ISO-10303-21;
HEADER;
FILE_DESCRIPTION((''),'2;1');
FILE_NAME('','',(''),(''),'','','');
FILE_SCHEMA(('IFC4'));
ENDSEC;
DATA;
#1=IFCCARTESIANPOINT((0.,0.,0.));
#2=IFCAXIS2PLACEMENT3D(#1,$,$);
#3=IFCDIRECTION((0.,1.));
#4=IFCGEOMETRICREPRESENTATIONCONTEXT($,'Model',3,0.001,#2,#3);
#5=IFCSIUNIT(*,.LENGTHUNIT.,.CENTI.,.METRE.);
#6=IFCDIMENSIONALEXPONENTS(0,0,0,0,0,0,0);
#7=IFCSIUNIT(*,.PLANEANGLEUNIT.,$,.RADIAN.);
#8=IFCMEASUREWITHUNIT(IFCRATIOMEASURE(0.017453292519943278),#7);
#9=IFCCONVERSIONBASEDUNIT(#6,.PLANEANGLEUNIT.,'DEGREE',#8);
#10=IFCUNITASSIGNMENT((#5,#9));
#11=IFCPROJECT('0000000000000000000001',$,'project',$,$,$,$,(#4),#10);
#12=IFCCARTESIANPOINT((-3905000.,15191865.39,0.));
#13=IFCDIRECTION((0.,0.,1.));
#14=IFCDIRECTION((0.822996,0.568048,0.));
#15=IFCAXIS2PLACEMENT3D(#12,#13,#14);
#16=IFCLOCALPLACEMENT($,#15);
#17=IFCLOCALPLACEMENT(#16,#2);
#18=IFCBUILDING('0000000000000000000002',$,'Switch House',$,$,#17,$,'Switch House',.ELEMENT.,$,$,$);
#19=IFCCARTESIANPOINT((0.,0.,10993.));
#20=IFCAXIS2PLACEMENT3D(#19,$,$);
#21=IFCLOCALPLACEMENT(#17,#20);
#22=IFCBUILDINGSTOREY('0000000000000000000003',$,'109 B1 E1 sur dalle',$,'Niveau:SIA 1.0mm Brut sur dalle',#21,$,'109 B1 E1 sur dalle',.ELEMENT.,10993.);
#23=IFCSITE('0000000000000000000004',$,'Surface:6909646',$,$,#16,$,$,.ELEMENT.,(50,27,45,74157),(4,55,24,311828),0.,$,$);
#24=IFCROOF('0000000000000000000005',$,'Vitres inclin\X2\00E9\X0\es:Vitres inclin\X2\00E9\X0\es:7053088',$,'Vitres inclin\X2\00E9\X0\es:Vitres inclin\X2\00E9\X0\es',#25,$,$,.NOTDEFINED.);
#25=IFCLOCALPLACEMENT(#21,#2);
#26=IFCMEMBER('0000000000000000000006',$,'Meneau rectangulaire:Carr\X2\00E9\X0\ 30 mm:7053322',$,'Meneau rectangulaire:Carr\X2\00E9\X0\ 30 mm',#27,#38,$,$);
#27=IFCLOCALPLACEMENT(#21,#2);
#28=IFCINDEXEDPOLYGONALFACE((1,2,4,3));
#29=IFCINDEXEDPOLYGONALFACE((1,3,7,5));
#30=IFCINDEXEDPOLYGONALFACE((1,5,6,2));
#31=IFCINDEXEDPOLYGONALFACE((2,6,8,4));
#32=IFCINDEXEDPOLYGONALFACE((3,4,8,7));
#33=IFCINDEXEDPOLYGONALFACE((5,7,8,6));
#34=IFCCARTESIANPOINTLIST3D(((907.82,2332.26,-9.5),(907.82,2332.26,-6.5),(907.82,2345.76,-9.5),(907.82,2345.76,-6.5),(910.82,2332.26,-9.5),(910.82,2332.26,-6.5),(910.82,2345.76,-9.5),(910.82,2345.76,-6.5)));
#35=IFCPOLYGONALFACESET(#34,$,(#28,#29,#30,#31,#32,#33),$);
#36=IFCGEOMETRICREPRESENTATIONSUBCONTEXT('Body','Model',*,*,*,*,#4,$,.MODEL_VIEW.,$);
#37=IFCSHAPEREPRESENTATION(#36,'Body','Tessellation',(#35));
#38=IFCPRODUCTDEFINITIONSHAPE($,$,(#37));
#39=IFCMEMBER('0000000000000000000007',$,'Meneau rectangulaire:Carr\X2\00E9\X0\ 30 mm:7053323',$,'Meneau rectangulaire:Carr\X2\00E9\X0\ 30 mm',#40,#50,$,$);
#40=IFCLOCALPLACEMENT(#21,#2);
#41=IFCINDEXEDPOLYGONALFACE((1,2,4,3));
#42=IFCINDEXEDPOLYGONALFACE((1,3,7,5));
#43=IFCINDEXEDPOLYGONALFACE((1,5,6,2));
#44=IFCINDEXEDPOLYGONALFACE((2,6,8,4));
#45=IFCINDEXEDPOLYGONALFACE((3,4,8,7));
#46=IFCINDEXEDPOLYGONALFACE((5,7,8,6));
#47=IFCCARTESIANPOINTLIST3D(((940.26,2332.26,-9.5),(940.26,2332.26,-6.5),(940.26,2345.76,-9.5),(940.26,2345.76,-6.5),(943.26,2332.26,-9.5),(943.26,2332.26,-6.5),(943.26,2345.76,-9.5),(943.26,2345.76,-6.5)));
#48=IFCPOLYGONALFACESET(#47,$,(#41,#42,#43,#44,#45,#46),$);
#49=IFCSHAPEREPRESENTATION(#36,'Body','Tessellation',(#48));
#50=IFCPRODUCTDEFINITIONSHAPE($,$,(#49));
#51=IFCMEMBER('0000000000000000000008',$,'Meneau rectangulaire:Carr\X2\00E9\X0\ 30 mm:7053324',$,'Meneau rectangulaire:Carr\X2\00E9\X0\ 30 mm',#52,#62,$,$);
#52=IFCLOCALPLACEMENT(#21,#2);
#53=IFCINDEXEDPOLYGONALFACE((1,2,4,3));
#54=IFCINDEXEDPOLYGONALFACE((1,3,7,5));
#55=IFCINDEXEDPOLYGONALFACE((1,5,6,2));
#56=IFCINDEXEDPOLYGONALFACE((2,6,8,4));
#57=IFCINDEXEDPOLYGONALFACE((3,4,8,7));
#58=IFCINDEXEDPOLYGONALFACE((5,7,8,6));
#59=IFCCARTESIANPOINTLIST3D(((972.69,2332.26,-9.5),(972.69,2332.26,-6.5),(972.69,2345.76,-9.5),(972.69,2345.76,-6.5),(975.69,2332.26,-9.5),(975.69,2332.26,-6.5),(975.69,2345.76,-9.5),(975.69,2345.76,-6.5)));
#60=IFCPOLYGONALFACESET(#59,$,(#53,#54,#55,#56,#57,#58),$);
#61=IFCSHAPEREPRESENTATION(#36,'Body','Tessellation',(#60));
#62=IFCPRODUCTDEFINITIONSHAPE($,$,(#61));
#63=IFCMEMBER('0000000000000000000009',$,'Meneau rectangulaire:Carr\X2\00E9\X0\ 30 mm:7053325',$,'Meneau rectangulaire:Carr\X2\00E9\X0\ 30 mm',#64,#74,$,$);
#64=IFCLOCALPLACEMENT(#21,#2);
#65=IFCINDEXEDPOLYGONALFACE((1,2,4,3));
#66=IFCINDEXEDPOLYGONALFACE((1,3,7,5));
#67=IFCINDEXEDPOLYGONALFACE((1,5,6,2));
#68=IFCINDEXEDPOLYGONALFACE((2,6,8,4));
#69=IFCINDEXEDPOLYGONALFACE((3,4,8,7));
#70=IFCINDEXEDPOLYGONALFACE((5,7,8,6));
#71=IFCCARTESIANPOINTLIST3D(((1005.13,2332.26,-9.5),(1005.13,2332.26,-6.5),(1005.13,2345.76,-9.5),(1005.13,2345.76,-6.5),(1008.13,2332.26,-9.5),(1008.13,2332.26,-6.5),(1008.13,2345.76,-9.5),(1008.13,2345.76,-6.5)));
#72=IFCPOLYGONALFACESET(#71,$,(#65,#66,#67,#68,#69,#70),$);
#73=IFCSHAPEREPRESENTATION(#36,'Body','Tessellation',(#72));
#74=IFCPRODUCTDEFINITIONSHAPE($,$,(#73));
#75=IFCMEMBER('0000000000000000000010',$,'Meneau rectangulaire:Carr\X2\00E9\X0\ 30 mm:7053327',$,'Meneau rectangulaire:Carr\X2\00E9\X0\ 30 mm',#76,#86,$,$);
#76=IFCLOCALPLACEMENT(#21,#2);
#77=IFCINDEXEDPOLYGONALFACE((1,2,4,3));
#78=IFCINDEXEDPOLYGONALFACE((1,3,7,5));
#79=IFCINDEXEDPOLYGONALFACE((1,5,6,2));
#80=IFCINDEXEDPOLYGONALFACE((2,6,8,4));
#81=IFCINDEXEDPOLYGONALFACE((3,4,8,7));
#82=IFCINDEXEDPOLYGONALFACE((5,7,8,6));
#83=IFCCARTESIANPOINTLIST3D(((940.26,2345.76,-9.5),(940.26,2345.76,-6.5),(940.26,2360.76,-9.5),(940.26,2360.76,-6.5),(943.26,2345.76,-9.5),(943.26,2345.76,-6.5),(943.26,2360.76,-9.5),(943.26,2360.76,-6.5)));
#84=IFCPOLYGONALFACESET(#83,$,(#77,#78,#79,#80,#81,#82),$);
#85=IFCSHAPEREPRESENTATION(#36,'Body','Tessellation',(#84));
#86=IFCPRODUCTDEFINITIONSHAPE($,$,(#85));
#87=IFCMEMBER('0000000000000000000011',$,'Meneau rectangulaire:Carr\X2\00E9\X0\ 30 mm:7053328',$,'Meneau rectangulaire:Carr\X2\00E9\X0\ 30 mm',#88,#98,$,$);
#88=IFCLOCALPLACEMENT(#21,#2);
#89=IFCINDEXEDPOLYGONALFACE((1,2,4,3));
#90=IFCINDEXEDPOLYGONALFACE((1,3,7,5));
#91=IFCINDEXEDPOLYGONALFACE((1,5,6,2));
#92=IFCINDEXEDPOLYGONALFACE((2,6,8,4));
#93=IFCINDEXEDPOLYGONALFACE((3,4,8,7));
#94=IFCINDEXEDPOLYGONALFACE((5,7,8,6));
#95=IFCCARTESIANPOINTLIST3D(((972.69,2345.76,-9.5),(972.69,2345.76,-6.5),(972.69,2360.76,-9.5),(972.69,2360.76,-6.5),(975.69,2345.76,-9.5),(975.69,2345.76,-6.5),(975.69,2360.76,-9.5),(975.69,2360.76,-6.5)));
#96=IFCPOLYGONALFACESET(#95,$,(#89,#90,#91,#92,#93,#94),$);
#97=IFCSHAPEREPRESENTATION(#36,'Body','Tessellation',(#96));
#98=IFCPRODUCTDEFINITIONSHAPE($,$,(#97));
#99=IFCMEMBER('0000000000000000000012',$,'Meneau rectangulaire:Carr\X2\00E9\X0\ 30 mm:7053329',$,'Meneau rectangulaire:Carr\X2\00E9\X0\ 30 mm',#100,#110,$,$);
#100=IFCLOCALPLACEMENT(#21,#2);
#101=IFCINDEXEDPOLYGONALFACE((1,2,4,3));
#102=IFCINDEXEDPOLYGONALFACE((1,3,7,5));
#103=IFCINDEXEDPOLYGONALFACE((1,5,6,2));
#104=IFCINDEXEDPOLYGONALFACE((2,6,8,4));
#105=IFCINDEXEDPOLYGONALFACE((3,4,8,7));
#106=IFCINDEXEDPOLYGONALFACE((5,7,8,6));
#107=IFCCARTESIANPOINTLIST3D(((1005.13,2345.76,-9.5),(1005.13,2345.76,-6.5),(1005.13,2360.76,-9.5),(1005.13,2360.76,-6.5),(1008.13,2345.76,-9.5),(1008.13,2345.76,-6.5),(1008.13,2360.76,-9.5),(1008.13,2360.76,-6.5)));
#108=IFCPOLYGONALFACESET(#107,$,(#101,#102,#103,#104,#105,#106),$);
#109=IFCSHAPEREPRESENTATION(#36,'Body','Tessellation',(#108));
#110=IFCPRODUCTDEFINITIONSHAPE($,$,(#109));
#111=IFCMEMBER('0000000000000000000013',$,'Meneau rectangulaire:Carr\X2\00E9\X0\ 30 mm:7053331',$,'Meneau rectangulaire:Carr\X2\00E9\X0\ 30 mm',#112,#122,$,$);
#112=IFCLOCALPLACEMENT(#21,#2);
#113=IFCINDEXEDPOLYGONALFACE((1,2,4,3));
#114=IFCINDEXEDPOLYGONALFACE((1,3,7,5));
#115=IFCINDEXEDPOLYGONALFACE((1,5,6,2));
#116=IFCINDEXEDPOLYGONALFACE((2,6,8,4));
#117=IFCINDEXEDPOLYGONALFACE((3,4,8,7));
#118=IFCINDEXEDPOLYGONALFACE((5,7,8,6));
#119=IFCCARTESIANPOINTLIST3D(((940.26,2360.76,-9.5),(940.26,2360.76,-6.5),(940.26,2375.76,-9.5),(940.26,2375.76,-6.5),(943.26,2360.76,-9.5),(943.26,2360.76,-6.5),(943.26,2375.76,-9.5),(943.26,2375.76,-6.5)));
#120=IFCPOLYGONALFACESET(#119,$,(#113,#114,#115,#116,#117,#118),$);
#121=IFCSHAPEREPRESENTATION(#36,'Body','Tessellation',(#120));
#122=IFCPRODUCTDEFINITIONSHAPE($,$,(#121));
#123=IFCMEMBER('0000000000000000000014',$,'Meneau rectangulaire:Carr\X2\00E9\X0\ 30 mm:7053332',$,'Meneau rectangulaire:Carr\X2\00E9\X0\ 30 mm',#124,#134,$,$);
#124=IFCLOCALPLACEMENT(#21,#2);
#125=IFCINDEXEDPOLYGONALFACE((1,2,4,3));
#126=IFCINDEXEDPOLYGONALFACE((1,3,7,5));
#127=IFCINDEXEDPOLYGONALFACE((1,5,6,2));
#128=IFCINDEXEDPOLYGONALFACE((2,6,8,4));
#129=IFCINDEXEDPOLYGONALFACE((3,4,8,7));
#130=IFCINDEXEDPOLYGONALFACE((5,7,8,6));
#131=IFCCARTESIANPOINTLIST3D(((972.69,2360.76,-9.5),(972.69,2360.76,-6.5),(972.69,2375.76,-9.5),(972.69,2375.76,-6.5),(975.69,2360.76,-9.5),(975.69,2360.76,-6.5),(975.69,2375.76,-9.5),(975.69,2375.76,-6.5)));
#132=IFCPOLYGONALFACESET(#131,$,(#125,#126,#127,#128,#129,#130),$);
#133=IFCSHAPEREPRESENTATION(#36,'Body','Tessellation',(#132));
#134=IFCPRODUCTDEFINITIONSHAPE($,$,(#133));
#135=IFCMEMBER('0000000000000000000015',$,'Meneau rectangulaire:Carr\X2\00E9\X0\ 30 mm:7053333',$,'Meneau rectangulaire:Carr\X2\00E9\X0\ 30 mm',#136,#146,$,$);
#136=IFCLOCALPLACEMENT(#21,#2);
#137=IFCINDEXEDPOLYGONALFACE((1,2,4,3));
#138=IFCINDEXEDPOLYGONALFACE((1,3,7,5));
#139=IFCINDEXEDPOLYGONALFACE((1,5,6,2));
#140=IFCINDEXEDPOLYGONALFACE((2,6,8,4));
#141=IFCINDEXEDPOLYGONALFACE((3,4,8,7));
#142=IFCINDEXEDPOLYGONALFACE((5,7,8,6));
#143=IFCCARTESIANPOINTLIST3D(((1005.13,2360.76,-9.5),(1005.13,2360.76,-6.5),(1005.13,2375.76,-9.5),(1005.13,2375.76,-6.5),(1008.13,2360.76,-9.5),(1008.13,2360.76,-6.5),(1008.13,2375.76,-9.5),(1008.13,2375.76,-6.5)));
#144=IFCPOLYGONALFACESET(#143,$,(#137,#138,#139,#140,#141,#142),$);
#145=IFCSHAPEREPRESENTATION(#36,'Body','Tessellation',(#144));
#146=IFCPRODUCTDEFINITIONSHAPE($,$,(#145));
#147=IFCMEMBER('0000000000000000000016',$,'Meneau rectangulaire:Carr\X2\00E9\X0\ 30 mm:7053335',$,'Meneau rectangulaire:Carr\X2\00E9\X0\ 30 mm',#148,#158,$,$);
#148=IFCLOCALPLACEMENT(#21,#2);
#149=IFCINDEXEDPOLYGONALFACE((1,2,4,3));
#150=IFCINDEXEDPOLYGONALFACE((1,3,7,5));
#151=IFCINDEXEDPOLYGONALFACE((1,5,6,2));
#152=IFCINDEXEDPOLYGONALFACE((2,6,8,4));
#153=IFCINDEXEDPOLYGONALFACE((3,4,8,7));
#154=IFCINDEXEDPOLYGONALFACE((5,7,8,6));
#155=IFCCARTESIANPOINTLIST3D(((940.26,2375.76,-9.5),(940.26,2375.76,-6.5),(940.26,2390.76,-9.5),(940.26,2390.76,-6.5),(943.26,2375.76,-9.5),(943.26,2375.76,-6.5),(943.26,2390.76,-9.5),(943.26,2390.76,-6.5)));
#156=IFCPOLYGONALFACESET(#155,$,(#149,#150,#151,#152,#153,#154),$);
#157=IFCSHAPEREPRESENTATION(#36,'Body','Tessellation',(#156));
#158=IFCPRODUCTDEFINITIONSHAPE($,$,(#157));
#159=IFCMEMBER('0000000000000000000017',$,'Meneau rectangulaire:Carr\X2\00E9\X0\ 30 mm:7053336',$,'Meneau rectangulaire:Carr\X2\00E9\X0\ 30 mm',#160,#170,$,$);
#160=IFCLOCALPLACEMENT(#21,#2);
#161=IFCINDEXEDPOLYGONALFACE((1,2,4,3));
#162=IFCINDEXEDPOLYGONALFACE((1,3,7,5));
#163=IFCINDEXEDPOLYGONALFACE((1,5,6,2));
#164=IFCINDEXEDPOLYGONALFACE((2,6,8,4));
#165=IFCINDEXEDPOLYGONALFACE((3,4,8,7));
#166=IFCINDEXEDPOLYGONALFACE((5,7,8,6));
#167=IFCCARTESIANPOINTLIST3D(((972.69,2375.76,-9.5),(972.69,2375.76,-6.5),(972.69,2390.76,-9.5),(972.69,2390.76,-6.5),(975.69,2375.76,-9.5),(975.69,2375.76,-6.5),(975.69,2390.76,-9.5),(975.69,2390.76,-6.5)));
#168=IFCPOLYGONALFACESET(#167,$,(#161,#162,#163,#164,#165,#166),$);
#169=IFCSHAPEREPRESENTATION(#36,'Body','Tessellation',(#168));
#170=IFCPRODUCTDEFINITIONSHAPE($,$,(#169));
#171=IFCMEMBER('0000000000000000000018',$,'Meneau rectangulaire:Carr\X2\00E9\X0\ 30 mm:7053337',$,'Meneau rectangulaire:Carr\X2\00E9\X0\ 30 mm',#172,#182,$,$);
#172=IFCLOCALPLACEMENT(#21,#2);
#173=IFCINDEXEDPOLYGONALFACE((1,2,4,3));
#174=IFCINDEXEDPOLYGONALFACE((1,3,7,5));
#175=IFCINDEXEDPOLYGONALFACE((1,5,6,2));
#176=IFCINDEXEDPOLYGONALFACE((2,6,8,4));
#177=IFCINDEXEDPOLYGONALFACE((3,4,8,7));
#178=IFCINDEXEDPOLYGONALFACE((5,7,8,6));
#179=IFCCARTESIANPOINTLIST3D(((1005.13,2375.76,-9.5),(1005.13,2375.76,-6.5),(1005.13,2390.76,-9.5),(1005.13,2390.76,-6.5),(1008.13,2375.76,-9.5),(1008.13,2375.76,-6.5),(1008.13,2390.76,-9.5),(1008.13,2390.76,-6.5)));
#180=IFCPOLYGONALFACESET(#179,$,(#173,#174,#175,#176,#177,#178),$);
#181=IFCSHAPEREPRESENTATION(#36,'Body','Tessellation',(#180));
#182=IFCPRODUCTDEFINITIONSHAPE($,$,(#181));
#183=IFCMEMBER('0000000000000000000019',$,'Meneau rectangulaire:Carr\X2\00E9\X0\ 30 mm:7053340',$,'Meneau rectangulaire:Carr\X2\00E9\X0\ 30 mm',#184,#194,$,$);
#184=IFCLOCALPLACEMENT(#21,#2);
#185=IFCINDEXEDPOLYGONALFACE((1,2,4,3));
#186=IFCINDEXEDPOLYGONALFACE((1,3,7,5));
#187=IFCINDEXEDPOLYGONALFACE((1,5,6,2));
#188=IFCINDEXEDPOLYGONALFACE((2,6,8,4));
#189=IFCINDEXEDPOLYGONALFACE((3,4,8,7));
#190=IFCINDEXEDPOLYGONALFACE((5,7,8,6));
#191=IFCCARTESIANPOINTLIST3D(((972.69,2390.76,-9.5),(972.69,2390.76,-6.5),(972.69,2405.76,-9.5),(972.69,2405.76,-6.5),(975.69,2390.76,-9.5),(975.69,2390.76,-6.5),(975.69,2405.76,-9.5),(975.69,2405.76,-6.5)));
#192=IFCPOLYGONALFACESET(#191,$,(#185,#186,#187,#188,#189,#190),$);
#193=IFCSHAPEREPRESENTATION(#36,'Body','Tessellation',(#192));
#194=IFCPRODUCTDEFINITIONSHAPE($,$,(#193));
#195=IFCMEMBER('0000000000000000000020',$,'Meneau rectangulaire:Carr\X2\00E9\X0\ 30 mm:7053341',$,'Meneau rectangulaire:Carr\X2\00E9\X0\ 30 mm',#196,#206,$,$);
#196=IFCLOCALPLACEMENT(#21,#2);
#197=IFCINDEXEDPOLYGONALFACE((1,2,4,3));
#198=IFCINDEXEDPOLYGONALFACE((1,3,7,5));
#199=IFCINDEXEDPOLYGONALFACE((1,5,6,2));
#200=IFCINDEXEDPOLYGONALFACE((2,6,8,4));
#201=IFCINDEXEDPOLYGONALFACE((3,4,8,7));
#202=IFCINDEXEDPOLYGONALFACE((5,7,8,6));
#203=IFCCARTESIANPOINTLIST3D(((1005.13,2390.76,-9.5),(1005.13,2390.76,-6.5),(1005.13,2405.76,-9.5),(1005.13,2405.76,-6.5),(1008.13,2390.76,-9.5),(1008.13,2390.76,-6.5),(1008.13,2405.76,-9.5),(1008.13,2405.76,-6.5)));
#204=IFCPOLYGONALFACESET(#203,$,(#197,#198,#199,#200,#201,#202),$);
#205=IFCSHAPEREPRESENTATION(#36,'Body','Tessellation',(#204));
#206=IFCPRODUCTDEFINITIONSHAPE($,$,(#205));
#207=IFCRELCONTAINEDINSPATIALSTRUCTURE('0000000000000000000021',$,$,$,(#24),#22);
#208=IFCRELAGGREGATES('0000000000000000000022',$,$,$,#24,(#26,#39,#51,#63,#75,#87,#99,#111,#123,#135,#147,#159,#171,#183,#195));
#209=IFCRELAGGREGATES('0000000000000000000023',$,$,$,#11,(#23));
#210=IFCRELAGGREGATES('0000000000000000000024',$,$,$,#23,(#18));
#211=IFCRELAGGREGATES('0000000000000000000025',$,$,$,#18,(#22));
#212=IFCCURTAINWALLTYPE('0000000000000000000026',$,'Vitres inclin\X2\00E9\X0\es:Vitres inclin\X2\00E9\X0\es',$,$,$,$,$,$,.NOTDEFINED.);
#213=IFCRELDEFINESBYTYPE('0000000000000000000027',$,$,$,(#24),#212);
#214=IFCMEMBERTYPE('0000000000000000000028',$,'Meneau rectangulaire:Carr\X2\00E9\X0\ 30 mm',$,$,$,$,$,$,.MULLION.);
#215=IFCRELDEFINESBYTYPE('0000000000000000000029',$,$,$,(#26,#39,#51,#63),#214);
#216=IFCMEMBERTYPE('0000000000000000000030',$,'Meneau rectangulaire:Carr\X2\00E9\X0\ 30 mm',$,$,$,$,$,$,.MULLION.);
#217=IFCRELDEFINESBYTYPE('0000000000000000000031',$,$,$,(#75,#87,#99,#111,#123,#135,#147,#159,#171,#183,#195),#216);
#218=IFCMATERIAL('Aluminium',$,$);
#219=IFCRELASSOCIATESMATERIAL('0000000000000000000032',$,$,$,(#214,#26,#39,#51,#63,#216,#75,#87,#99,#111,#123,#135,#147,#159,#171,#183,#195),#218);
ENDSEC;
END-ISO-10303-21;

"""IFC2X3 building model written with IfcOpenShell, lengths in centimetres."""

from ifc_helpers import new_model, entity, si_unit, converted_unit, direction, frame, origin, origin_2d_with_axis, place, context, subcontext, project, spatial, rectangle, extrude, source, transform, mapped, material, type_object, type_shapes, element, aggregate, save


model = new_model("IFC2X3")

# Units and contexts
model_context = context("Model", 3, precision=0.001, world=origin(), true_north=direction((0.0, 1.0)))
body_context = subcontext(model_context, "Body", "Model", "MODEL_VIEW")
ifc_project = project(units=[si_unit("LENGTHUNIT", "METRE", prefix="CENTI"), converted_unit("PLANEANGLEUNIT", "DEGREE", entity("IfcRatioMeasure", 0.017453292519943278), si_unit("PLANEANGLEUNIT", "RADIAN"), dimensions=[0, 0, 0, 0, 0, 0, 0])], contexts=[model_context])

# Site, building, storey
site_placement = place(None, frame((-3905000.0, 15191865.39, 0.0), z_axis=(0.0, 0.0, 1.0), x_axis=(0.822996, 0.568048, 0.0)))
site = spatial("IfcSite", under=ifc_project, at=site_placement, Name="Surface:6909646", CompositionType="ELEMENT", RefLatitude=(50, 27, 45, 74157), RefLongitude=(4, 55, 24, 311828), RefElevation=0.0)
building_placement = place(site_placement, origin())
building = spatial("IfcBuilding", under=site, at=building_placement, Name="Switch House", LongName="Switch House", CompositionType="ELEMENT")
storey_placement = place(building_placement, frame((0.0, 0.0, 10993.0)))
storey = spatial("IfcBuildingStorey", under=building, at=storey_placement, Name="109 B1 E1 sur dalle", ObjectType="Niveau:SIA 1.0mm Brut sur dalle", LongName="109 B1 E1 sur dalle", CompositionType="ELEMENT", Elevation=10993.0)

# Roof, members
curtain_wall_type = type_object("IfcCurtainWallType", Name="Vitres inclinées:Vitres inclinées", PredefinedType="NOTDEFINED")
roof_placement = place(storey_placement, frame((0.0, 0.0, -10993.0)))
roof = element("IfcRoof", 1, at=roof_placement, inside=storey, type_object=curtain_wall_type, Name="Vitres inclinées:Vitres inclinées:7053088", ObjectType="Vitres inclinées:Vitres inclinées", ShapeType="NOTDEFINED")
ifc_material = material(Name="Aluminium")
member_type_1 = type_object("IfcMemberType", Name="Meneau rectangulaire:Carré 30 mm", PredefinedType="MULLION", material=ifc_material)
shared_shape_1 = source(origin(), body_context, "Body", "SweptSolid", [
    extrude(rectangle(XDim=3.0, YDim=3.0, at=origin_2d_with_axis()), frame((0.0, 0.0, -13.5), z_axis=(0.0, 0.0, 1.0), x_axis=(0.0, -1.0, 0.0)), (0.0, 0.0, 1.0), 13.5),
])
type_shapes(member_type_1, [shared_shape_1])
member_1_placement = place(roof_placement, frame((909.32, 2345.76, 10985.0), z_axis=(0.0, 1.0, 0.0), x_axis=(1.0, 0.0, 0.0)))
member_1 = element("IfcMember", 2, at=member_1_placement, type_object=member_type_1, material=ifc_material, Name="Meneau rectangulaire:Carré 30 mm:7053322", ObjectType="Meneau rectangulaire:Carré 30 mm", context=body_context, shape_type="MappedRepresentation", body=[
    mapped(shared_shape_1, transform((0.0, 0.0, 0.0), scale=1.0)),
])
member_2_placement = place(roof_placement, frame((941.76, 2345.76, 10985.0), z_axis=(0.0, 1.0, 0.0), x_axis=(1.0, 0.0, 0.0)))
member_2 = element("IfcMember", 3, at=member_2_placement, type_object=member_type_1, material=ifc_material, Name="Meneau rectangulaire:Carré 30 mm:7053323", ObjectType="Meneau rectangulaire:Carré 30 mm", context=body_context, shape_type="MappedRepresentation", body=[
    mapped(shared_shape_1, transform((0.0, 0.0, 0.0), scale=1.0)),
])
member_3_placement = place(roof_placement, frame((974.19, 2345.76, 10985.0), z_axis=(0.0, 1.0, 0.0), x_axis=(1.0, 0.0, 0.0)))
member_3 = element("IfcMember", 4, at=member_3_placement, type_object=member_type_1, material=ifc_material, Name="Meneau rectangulaire:Carré 30 mm:7053324", ObjectType="Meneau rectangulaire:Carré 30 mm", context=body_context, shape_type="MappedRepresentation", body=[
    mapped(shared_shape_1, transform((0.0, 0.0, 0.0), scale=1.0)),
])
member_4_placement = place(roof_placement, frame((1006.63, 2345.76, 10985.0), z_axis=(0.0, 1.0, 0.0), x_axis=(1.0, 0.0, 0.0)))
member_4 = element("IfcMember", 5, at=member_4_placement, type_object=member_type_1, material=ifc_material, Name="Meneau rectangulaire:Carré 30 mm:7053325", ObjectType="Meneau rectangulaire:Carré 30 mm", context=body_context, shape_type="MappedRepresentation", body=[
    mapped(shared_shape_1, transform((0.0, 0.0, 0.0), scale=1.0)),
])
member_type_2 = type_object("IfcMemberType", Name="Meneau rectangulaire:Carré 30 mm", PredefinedType="MULLION", material=ifc_material)
shared_shape_2 = source(origin(), body_context, "Body", "SweptSolid", [
    extrude(rectangle(XDim=3.0, YDim=3.0, at=origin_2d_with_axis()), frame((0.0, 0.0, -15.0), z_axis=(0.0, 0.0, 1.0), x_axis=(0.0, -1.0, 0.0)), (0.0, 0.0, 1.0), 15.0),
])
type_shapes(member_type_2, [shared_shape_2])
member_5_placement = place(roof_placement, frame((941.76, 2360.76, 10985.0), z_axis=(0.0, 1.0, 0.0), x_axis=(1.0, 0.0, 0.0)))
member_5 = element("IfcMember", 6, at=member_5_placement, type_object=member_type_2, material=ifc_material, Name="Meneau rectangulaire:Carré 30 mm:7053327", ObjectType="Meneau rectangulaire:Carré 30 mm", context=body_context, shape_type="MappedRepresentation", body=[
    mapped(shared_shape_2, transform((0.0, 0.0, 0.0), scale=1.0)),
])
member_6_placement = place(roof_placement, frame((974.19, 2360.76, 10985.0), z_axis=(0.0, 1.0, 0.0), x_axis=(1.0, 0.0, 0.0)))
member_6 = element("IfcMember", 7, at=member_6_placement, type_object=member_type_2, material=ifc_material, Name="Meneau rectangulaire:Carré 30 mm:7053328", ObjectType="Meneau rectangulaire:Carré 30 mm", context=body_context, shape_type="MappedRepresentation", body=[
    mapped(shared_shape_2, transform((0.0, 0.0, 0.0), scale=1.0)),
])
member_7_placement = place(roof_placement, frame((1006.63, 2360.76, 10985.0), z_axis=(0.0, 1.0, 0.0), x_axis=(1.0, 0.0, 0.0)))
member_7 = element("IfcMember", 8, at=member_7_placement, type_object=member_type_2, material=ifc_material, Name="Meneau rectangulaire:Carré 30 mm:7053329", ObjectType="Meneau rectangulaire:Carré 30 mm", context=body_context, shape_type="MappedRepresentation", body=[
    mapped(shared_shape_2, transform((0.0, 0.0, 0.0), scale=1.0)),
])
member_8_placement = place(roof_placement, frame((941.76, 2375.76, 10985.0), z_axis=(0.0, 1.0, 0.0), x_axis=(1.0, 0.0, 0.0)))
member_8 = element("IfcMember", 9, at=member_8_placement, type_object=member_type_2, material=ifc_material, Name="Meneau rectangulaire:Carré 30 mm:7053331", ObjectType="Meneau rectangulaire:Carré 30 mm", context=body_context, shape_type="MappedRepresentation", body=[
    mapped(shared_shape_2, transform((0.0, 0.0, 0.0), scale=1.0)),
])
member_9_placement = place(roof_placement, frame((974.19, 2375.76, 10985.0), z_axis=(0.0, 1.0, 0.0), x_axis=(1.0, 0.0, 0.0)))
member_9 = element("IfcMember", 10, at=member_9_placement, type_object=member_type_2, material=ifc_material, Name="Meneau rectangulaire:Carré 30 mm:7053332", ObjectType="Meneau rectangulaire:Carré 30 mm", context=body_context, shape_type="MappedRepresentation", body=[
    mapped(shared_shape_2, transform((0.0, 0.0, 0.0), scale=1.0)),
])
member_10_placement = place(roof_placement, frame((1006.63, 2375.76, 10985.0), z_axis=(0.0, 1.0, 0.0), x_axis=(1.0, 0.0, 0.0)))
member_10 = element("IfcMember", 11, at=member_10_placement, type_object=member_type_2, material=ifc_material, Name="Meneau rectangulaire:Carré 30 mm:7053333", ObjectType="Meneau rectangulaire:Carré 30 mm", context=body_context, shape_type="MappedRepresentation", body=[
    mapped(shared_shape_2, transform((0.0, 0.0, 0.0), scale=1.0)),
])
member_11_placement = place(roof_placement, frame((941.76, 2390.76, 10985.0), z_axis=(0.0, 1.0, 0.0), x_axis=(1.0, 0.0, 0.0)))
member_11 = element("IfcMember", 12, at=member_11_placement, type_object=member_type_2, material=ifc_material, Name="Meneau rectangulaire:Carré 30 mm:7053335", ObjectType="Meneau rectangulaire:Carré 30 mm", context=body_context, shape_type="MappedRepresentation", body=[
    mapped(shared_shape_2, transform((0.0, 0.0, 0.0), scale=1.0)),
])
member_12_placement = place(roof_placement, frame((974.19, 2390.76, 10985.0), z_axis=(0.0, 1.0, 0.0), x_axis=(1.0, 0.0, 0.0)))
member_12 = element("IfcMember", 13, at=member_12_placement, type_object=member_type_2, material=ifc_material, Name="Meneau rectangulaire:Carré 30 mm:7053336", ObjectType="Meneau rectangulaire:Carré 30 mm", context=body_context, shape_type="MappedRepresentation", body=[
    mapped(shared_shape_2, transform((0.0, 0.0, 0.0), scale=1.0)),
])
member_13_placement = place(roof_placement, frame((1006.63, 2390.76, 10985.0), z_axis=(0.0, 1.0, 0.0), x_axis=(1.0, 0.0, 0.0)))
member_13 = element("IfcMember", 14, at=member_13_placement, type_object=member_type_2, material=ifc_material, Name="Meneau rectangulaire:Carré 30 mm:7053337", ObjectType="Meneau rectangulaire:Carré 30 mm", context=body_context, shape_type="MappedRepresentation", body=[
    mapped(shared_shape_2, transform((0.0, 0.0, 0.0), scale=1.0)),
])
member_14_placement = place(roof_placement, frame((974.19, 2405.76, 10985.0), z_axis=(0.0, 1.0, 0.0), x_axis=(1.0, 0.0, 0.0)))
member_14 = element("IfcMember", 15, at=member_14_placement, type_object=member_type_2, material=ifc_material, Name="Meneau rectangulaire:Carré 30 mm:7053340", ObjectType="Meneau rectangulaire:Carré 30 mm", context=body_context, shape_type="MappedRepresentation", body=[
    mapped(shared_shape_2, transform((0.0, 0.0, 0.0), scale=1.0)),
])
member_15_placement = place(roof_placement, frame((1006.63, 2405.76, 10985.0), z_axis=(0.0, 1.0, 0.0), x_axis=(1.0, 0.0, 0.0)))
member_15 = element("IfcMember", 16, at=member_15_placement, type_object=member_type_2, material=ifc_material, Name="Meneau rectangulaire:Carré 30 mm:7053341", ObjectType="Meneau rectangulaire:Carré 30 mm", context=body_context, shape_type="MappedRepresentation", body=[
    mapped(shared_shape_2, transform((0.0, 0.0, 0.0), scale=1.0)),
])
aggregate(roof, [member_1, member_2, member_3, member_4, member_5, member_6, member_7, member_8, member_9, member_10, member_11, member_12, member_13, member_14, member_15])

save(model, "model.ifc")
